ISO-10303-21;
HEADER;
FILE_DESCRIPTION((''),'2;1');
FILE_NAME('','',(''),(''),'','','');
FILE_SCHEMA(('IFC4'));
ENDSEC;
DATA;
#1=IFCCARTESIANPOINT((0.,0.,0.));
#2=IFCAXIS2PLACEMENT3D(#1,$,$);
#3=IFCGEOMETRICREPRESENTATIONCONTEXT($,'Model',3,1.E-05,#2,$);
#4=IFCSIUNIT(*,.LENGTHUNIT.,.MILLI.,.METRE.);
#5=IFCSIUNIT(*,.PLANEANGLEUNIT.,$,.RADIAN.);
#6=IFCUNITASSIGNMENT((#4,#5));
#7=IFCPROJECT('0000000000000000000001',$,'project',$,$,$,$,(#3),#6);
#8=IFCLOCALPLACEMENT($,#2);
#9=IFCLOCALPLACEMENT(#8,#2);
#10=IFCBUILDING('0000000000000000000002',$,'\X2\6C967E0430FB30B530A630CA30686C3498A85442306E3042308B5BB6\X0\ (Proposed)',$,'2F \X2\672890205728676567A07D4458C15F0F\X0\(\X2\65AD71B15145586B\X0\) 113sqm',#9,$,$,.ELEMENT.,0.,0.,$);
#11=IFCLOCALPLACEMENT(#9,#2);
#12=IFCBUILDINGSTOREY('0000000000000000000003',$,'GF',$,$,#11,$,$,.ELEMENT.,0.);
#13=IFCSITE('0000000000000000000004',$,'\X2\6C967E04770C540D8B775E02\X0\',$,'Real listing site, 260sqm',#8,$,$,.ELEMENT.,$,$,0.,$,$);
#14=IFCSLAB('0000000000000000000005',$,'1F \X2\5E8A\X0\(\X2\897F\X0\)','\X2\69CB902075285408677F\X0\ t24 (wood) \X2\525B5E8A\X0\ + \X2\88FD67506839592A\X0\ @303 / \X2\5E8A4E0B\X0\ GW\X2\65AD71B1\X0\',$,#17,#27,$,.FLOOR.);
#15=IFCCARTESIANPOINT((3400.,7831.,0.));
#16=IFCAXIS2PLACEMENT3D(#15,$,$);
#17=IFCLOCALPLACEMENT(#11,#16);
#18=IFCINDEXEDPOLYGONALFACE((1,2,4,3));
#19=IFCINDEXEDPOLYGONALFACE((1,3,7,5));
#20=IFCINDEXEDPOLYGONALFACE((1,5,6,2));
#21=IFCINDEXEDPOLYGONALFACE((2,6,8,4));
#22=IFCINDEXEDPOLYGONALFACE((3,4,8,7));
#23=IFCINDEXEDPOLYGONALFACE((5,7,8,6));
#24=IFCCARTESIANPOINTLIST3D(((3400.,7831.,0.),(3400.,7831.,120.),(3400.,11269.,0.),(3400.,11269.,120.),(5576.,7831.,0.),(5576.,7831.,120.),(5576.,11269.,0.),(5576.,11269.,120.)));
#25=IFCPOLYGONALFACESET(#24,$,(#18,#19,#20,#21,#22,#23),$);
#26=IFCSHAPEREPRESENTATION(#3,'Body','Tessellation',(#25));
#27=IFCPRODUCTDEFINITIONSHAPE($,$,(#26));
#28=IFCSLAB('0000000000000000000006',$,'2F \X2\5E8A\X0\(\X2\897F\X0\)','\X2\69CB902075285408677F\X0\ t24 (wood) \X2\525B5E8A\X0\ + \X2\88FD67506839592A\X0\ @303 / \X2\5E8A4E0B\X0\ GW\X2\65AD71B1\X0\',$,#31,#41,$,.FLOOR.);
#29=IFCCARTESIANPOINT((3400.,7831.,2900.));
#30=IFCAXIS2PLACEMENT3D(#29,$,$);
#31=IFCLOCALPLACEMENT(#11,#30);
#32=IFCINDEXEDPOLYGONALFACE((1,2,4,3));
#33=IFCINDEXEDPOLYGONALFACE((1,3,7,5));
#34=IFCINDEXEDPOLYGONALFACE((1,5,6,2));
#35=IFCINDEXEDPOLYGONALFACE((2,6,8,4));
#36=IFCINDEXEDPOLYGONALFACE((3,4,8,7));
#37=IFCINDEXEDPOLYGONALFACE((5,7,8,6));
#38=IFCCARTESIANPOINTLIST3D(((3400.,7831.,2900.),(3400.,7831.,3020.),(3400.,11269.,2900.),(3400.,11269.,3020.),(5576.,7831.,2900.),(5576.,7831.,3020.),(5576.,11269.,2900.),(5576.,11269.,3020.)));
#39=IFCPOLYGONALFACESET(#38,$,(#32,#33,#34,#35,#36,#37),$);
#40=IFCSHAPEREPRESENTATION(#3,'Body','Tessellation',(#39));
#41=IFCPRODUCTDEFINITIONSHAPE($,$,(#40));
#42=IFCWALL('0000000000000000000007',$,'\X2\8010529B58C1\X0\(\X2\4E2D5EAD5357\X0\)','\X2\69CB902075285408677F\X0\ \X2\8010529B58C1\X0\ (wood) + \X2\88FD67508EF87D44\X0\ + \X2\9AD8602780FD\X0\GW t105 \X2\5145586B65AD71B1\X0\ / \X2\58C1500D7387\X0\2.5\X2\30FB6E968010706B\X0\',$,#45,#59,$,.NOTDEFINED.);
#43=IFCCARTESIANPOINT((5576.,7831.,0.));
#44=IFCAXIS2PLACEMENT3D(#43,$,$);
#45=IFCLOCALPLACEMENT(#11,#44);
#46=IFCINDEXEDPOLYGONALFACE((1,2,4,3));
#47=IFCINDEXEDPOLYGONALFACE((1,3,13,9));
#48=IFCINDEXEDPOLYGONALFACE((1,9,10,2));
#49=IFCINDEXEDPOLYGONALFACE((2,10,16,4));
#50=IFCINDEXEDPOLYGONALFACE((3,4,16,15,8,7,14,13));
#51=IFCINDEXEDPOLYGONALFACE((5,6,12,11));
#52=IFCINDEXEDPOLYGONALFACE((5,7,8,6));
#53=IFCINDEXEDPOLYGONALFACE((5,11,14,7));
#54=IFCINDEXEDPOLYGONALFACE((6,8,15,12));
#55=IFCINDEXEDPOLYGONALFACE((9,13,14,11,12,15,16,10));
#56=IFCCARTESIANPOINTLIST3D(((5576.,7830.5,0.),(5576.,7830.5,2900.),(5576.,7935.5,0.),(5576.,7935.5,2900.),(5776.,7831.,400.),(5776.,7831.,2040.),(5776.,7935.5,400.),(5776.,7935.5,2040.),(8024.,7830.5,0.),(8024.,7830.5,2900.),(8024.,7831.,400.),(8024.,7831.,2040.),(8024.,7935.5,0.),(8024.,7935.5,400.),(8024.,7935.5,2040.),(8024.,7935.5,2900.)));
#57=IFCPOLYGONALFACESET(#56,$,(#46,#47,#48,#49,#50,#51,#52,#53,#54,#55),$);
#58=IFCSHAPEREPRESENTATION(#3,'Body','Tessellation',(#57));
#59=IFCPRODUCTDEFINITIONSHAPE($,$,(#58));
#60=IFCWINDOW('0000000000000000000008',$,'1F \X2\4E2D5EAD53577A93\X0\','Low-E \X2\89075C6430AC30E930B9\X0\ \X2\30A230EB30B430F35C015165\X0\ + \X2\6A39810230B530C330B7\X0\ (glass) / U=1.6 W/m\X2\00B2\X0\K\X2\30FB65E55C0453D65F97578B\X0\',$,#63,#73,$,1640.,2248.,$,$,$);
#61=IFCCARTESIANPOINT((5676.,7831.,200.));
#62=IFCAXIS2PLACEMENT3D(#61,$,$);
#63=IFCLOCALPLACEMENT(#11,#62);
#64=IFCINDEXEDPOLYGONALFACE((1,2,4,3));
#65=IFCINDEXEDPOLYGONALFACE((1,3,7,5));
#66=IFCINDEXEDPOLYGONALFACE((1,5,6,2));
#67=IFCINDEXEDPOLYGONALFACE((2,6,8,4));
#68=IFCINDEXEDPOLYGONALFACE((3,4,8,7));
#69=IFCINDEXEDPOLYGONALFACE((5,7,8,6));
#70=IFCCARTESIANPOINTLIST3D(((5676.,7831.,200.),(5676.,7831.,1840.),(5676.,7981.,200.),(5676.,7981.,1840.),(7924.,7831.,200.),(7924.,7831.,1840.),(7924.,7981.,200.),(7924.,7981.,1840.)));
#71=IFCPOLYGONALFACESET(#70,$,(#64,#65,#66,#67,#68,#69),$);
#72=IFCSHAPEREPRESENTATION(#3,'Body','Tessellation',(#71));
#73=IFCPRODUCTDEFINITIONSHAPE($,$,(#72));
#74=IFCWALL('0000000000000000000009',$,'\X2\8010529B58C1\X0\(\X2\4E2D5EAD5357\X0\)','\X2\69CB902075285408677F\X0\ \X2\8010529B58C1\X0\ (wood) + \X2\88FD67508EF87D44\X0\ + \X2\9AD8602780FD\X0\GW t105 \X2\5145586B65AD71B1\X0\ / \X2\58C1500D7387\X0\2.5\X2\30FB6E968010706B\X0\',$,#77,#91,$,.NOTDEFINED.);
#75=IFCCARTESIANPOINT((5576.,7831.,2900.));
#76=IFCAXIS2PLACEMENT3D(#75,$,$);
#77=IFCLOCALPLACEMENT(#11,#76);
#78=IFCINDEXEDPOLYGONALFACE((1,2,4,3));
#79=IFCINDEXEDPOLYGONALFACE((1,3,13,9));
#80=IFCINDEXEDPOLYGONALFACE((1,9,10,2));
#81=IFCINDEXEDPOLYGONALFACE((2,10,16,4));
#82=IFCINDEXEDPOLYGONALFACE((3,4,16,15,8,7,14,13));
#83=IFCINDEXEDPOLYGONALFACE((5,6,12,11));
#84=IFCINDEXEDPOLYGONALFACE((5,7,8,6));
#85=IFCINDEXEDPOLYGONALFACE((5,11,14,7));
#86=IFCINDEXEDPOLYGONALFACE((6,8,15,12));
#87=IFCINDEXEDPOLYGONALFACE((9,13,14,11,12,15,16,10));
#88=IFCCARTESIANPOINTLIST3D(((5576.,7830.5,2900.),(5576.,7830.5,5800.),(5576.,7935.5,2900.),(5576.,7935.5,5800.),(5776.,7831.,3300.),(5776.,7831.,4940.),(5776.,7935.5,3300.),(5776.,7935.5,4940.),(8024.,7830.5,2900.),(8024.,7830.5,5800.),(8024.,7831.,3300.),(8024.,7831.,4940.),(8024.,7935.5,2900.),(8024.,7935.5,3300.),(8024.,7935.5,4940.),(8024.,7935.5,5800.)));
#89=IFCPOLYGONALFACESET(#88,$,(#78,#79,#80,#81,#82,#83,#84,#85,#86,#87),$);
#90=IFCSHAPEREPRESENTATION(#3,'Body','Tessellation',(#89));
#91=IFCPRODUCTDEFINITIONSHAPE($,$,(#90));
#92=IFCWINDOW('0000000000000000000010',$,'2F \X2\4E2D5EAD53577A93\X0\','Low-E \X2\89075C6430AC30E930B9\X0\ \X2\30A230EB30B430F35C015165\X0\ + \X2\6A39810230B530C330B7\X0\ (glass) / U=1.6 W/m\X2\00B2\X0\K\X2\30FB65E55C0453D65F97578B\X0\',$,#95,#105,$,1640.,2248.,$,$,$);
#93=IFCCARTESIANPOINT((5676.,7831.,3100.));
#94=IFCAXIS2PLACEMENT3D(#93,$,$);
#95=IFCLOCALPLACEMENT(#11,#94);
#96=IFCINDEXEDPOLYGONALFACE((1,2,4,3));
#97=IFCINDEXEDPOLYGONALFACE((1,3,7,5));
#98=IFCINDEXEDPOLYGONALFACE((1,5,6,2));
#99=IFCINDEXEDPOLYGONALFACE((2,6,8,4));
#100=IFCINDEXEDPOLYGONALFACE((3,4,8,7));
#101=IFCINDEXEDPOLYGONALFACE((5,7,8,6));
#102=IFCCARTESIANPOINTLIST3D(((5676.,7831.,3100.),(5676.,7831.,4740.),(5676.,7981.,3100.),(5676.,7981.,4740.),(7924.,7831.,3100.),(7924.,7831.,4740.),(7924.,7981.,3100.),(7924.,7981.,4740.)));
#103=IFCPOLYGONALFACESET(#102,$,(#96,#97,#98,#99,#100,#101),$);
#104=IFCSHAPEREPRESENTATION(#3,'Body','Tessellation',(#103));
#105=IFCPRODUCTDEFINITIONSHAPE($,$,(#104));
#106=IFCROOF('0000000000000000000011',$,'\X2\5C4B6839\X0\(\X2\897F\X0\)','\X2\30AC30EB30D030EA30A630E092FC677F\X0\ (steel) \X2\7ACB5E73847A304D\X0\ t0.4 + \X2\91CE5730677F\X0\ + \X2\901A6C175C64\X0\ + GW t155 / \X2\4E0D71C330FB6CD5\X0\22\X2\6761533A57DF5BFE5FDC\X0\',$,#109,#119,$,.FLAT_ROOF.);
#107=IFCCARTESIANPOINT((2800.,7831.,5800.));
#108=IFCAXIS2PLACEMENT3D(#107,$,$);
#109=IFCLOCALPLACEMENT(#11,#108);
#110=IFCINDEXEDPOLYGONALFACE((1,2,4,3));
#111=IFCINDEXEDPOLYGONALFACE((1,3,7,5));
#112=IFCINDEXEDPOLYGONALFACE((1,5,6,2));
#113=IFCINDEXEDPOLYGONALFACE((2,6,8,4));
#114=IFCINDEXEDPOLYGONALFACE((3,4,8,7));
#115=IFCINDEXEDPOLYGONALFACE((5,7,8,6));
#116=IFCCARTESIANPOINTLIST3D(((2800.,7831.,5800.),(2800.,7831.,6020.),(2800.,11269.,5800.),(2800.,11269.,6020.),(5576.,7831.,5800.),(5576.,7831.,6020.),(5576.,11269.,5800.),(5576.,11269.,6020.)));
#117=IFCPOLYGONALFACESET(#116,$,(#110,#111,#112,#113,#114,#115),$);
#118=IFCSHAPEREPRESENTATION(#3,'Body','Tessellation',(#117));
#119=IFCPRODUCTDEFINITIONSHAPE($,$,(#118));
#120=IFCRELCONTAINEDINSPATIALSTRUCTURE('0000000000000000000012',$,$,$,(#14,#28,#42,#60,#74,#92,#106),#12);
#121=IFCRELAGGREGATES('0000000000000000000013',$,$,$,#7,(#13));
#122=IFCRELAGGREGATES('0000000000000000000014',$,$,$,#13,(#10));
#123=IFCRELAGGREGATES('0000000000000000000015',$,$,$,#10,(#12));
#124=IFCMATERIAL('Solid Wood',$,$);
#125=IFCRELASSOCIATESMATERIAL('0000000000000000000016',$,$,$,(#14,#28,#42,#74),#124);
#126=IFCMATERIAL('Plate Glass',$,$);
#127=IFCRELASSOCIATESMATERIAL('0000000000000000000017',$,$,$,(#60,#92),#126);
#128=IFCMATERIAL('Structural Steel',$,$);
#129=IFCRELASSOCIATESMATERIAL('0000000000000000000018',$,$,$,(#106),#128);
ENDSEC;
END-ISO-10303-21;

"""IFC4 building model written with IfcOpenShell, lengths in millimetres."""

from ifc_helpers import new_model, si_unit, frame, frame_2d, origin, place, context, project, spatial, rectangle, extrude, material, element, fill, save


model = new_model("IFC4")

# Units and contexts
model_context = context("Model", 3, precision=1e-05, world=origin())
ifc_project = project(units=[si_unit("LENGTHUNIT", "METRE", prefix="MILLI"), si_unit("PLANEANGLEUNIT", "RADIAN")], contexts=[model_context])

# Site, building, storey
site_placement = place(None, origin())
site = spatial("IfcSite", under=ifc_project, at=site_placement, Name="沖縄県名護市", ObjectType="Real listing site, 260sqm", CompositionType="ELEMENT", RefElevation=0.0)
building_placement = place(site_placement, origin())
building = spatial("IfcBuilding", under=site, at=building_placement, Name="沖縄・サウナと水風呂のある家 (Proposed)", ObjectType="2F 木造在来枠組壁式(断熱充填) 113sqm", CompositionType="ELEMENT", ElevationOfRefHeight=0.0, ElevationOfTerrain=0.0)
storey_placement = place(building_placement, origin())
storey = spatial("IfcBuildingStorey", under=building, at=storey_placement, Name="GF", CompositionType="ELEMENT", Elevation=0.0)

# Shared definitions
ifc_material_1 = material(Name="Solid Wood")

# Slabs
slab_1_placement = place(storey_placement, frame((3400.0, 7831.0, 0.0)))
element("IfcSlab", 1, at=slab_1_placement, inside=storey, material=ifc_material_1, Name="1F 床(西)", Description="構造用合板 t24 (wood) 剛床 + 製材根太 @303 / 床下 GW断熱", PredefinedType="FLOOR", context=model_context, shape_type="SweptSolid", body=[
    extrude(rectangle(XDim=2176.0, YDim=3438.0, at=frame_2d((1088.0, 1719.0))), frame((3400.0, 7831.0, 0.0)), (0.0, 0.0, 1.0), 120.0),
])
slab_2_placement = place(storey_placement, frame((3400.0, 7831.0, 2900.0)))
element("IfcSlab", 2, at=slab_2_placement, inside=storey, material=ifc_material_1, Name="2F 床(西)", Description="構造用合板 t24 (wood) 剛床 + 製材根太 @303 / 床下 GW断熱", PredefinedType="FLOOR", context=model_context, shape_type="SweptSolid", body=[
    extrude(rectangle(XDim=2176.0, YDim=3438.0, at=frame_2d((1088.0, 1719.0))), frame((3400.0, 7831.0, 2900.0)), (0.0, 0.0, 1.0), 120.0),
])

# Wall, opening, window
wall_1_placement = place(storey_placement, frame((5576.0, 7831.0, 0.0)))
wall_1 = element("IfcWall", 3, at=wall_1_placement, inside=storey, material=ifc_material_1, Name="耐力壁(中庭南)", Description="構造用合板 耐力壁 (wood) + 製材軸組 + 高性能GW t105 充填断熱 / 壁倍率2.5・準耐火", PredefinedType="NOTDEFINED", context=model_context, shape_type="SweptSolid", body=[
    extrude(rectangle(XDim=2448.0, YDim=105.0, at=frame_2d((1224.0, 52.0))), frame((5576.0, 7831.0, 0.0)), (0.0, 0.0, 1.0), 2900.0),
])
opening_1_placement = place(storey_placement, frame((5676.0, 7831.0, 200.0)))
opening_1 = element("IfcOpeningElement", 4, at=opening_1_placement, cuts=wall_1, PredefinedType="NOTDEFINED", context=model_context, shape_type="SweptSolid", body=[
    extrude(rectangle(XDim=2248.0, YDim=150.0, at=frame_2d((1124.0, 75.0))), frame((5676.0, 7831.0, 200.0)), (0.0, 0.0, 1.0), 1640.0),
])
ifc_material_2 = material(Name="Plate Glass")
window_1_placement = place(storey_placement, frame((5676.0, 7831.0, 200.0)))
window_1 = element("IfcWindow", 5, at=window_1_placement, inside=storey, material=ifc_material_2, Name="1F 中庭南窓", Description="Low-E 複層ガラス アルゴン封入 + 樹脂サッシ (glass) / U=1.6 W/m²K・日射取得型", OverallHeight=1640.0, OverallWidth=2248.0, context=model_context, shape_type="SweptSolid", body=[
    extrude(rectangle(XDim=2248.0, YDim=150.0, at=frame_2d((1124.0, 75.0))), frame((5676.0, 7831.0, 200.0)), (0.0, 0.0, 1.0), 1640.0),
])
fill(opening_1, window_1)

# Wall, opening, window
wall_2_placement = place(storey_placement, frame((5576.0, 7831.0, 2900.0)))
wall_2 = element("IfcWall", 6, at=wall_2_placement, inside=storey, material=ifc_material_1, Name="耐力壁(中庭南)", Description="構造用合板 耐力壁 (wood) + 製材軸組 + 高性能GW t105 充填断熱 / 壁倍率2.5・準耐火", PredefinedType="NOTDEFINED", context=model_context, shape_type="SweptSolid", body=[
    extrude(rectangle(XDim=2448.0, YDim=105.0, at=frame_2d((1224.0, 52.0))), frame((5576.0, 7831.0, 2900.0)), (0.0, 0.0, 1.0), 2900.0),
])
opening_2_placement = place(storey_placement, frame((5676.0, 7831.0, 3100.0)))
opening_2 = element("IfcOpeningElement", 7, at=opening_2_placement, cuts=wall_2, PredefinedType="NOTDEFINED", context=model_context, shape_type="SweptSolid", body=[
    extrude(rectangle(XDim=2248.0, YDim=150.0, at=frame_2d((1124.0, 75.0))), frame((5676.0, 7831.0, 3100.0)), (0.0, 0.0, 1.0), 1640.0),
])
window_2_placement = place(storey_placement, frame((5676.0, 7831.0, 3100.0)))
window_2 = element("IfcWindow", 8, at=window_2_placement, inside=storey, material=ifc_material_2, Name="2F 中庭南窓", Description="Low-E 複層ガラス アルゴン封入 + 樹脂サッシ (glass) / U=1.6 W/m²K・日射取得型", OverallHeight=1640.0, OverallWidth=2248.0, context=model_context, shape_type="SweptSolid", body=[
    extrude(rectangle(XDim=2248.0, YDim=150.0, at=frame_2d((1124.0, 75.0))), frame((5676.0, 7831.0, 3100.0)), (0.0, 0.0, 1.0), 1640.0),
])
fill(opening_2, window_2)

# Roof
ifc_material_3 = material(Name="Structural Steel")
for number, where, name in (
    (9, (2800.0, 7831.0, 5800.0), "屋根(西)"),
):
    element("IfcRoof", number, at=place(storey_placement, frame(where)), inside=storey, material=ifc_material_3, Name=name, Description="ガルバリウム鋼板 (steel) 立平葺き t0.4 + 野地板 + 通気層 + GW t155 / 不燃・法22条区域対応", PredefinedType="FLAT_ROOF", context=model_context, shape_type="SweptSolid", body=[
        extrude(rectangle(XDim=2776.0, YDim=3438.0, at=frame_2d((1388.0, 1719.0))), frame((2800.0, 7831.0, 5800.0)), (0.0, 0.0, 1.0), 220.0),
    ])

save(model, "model.ifc")
